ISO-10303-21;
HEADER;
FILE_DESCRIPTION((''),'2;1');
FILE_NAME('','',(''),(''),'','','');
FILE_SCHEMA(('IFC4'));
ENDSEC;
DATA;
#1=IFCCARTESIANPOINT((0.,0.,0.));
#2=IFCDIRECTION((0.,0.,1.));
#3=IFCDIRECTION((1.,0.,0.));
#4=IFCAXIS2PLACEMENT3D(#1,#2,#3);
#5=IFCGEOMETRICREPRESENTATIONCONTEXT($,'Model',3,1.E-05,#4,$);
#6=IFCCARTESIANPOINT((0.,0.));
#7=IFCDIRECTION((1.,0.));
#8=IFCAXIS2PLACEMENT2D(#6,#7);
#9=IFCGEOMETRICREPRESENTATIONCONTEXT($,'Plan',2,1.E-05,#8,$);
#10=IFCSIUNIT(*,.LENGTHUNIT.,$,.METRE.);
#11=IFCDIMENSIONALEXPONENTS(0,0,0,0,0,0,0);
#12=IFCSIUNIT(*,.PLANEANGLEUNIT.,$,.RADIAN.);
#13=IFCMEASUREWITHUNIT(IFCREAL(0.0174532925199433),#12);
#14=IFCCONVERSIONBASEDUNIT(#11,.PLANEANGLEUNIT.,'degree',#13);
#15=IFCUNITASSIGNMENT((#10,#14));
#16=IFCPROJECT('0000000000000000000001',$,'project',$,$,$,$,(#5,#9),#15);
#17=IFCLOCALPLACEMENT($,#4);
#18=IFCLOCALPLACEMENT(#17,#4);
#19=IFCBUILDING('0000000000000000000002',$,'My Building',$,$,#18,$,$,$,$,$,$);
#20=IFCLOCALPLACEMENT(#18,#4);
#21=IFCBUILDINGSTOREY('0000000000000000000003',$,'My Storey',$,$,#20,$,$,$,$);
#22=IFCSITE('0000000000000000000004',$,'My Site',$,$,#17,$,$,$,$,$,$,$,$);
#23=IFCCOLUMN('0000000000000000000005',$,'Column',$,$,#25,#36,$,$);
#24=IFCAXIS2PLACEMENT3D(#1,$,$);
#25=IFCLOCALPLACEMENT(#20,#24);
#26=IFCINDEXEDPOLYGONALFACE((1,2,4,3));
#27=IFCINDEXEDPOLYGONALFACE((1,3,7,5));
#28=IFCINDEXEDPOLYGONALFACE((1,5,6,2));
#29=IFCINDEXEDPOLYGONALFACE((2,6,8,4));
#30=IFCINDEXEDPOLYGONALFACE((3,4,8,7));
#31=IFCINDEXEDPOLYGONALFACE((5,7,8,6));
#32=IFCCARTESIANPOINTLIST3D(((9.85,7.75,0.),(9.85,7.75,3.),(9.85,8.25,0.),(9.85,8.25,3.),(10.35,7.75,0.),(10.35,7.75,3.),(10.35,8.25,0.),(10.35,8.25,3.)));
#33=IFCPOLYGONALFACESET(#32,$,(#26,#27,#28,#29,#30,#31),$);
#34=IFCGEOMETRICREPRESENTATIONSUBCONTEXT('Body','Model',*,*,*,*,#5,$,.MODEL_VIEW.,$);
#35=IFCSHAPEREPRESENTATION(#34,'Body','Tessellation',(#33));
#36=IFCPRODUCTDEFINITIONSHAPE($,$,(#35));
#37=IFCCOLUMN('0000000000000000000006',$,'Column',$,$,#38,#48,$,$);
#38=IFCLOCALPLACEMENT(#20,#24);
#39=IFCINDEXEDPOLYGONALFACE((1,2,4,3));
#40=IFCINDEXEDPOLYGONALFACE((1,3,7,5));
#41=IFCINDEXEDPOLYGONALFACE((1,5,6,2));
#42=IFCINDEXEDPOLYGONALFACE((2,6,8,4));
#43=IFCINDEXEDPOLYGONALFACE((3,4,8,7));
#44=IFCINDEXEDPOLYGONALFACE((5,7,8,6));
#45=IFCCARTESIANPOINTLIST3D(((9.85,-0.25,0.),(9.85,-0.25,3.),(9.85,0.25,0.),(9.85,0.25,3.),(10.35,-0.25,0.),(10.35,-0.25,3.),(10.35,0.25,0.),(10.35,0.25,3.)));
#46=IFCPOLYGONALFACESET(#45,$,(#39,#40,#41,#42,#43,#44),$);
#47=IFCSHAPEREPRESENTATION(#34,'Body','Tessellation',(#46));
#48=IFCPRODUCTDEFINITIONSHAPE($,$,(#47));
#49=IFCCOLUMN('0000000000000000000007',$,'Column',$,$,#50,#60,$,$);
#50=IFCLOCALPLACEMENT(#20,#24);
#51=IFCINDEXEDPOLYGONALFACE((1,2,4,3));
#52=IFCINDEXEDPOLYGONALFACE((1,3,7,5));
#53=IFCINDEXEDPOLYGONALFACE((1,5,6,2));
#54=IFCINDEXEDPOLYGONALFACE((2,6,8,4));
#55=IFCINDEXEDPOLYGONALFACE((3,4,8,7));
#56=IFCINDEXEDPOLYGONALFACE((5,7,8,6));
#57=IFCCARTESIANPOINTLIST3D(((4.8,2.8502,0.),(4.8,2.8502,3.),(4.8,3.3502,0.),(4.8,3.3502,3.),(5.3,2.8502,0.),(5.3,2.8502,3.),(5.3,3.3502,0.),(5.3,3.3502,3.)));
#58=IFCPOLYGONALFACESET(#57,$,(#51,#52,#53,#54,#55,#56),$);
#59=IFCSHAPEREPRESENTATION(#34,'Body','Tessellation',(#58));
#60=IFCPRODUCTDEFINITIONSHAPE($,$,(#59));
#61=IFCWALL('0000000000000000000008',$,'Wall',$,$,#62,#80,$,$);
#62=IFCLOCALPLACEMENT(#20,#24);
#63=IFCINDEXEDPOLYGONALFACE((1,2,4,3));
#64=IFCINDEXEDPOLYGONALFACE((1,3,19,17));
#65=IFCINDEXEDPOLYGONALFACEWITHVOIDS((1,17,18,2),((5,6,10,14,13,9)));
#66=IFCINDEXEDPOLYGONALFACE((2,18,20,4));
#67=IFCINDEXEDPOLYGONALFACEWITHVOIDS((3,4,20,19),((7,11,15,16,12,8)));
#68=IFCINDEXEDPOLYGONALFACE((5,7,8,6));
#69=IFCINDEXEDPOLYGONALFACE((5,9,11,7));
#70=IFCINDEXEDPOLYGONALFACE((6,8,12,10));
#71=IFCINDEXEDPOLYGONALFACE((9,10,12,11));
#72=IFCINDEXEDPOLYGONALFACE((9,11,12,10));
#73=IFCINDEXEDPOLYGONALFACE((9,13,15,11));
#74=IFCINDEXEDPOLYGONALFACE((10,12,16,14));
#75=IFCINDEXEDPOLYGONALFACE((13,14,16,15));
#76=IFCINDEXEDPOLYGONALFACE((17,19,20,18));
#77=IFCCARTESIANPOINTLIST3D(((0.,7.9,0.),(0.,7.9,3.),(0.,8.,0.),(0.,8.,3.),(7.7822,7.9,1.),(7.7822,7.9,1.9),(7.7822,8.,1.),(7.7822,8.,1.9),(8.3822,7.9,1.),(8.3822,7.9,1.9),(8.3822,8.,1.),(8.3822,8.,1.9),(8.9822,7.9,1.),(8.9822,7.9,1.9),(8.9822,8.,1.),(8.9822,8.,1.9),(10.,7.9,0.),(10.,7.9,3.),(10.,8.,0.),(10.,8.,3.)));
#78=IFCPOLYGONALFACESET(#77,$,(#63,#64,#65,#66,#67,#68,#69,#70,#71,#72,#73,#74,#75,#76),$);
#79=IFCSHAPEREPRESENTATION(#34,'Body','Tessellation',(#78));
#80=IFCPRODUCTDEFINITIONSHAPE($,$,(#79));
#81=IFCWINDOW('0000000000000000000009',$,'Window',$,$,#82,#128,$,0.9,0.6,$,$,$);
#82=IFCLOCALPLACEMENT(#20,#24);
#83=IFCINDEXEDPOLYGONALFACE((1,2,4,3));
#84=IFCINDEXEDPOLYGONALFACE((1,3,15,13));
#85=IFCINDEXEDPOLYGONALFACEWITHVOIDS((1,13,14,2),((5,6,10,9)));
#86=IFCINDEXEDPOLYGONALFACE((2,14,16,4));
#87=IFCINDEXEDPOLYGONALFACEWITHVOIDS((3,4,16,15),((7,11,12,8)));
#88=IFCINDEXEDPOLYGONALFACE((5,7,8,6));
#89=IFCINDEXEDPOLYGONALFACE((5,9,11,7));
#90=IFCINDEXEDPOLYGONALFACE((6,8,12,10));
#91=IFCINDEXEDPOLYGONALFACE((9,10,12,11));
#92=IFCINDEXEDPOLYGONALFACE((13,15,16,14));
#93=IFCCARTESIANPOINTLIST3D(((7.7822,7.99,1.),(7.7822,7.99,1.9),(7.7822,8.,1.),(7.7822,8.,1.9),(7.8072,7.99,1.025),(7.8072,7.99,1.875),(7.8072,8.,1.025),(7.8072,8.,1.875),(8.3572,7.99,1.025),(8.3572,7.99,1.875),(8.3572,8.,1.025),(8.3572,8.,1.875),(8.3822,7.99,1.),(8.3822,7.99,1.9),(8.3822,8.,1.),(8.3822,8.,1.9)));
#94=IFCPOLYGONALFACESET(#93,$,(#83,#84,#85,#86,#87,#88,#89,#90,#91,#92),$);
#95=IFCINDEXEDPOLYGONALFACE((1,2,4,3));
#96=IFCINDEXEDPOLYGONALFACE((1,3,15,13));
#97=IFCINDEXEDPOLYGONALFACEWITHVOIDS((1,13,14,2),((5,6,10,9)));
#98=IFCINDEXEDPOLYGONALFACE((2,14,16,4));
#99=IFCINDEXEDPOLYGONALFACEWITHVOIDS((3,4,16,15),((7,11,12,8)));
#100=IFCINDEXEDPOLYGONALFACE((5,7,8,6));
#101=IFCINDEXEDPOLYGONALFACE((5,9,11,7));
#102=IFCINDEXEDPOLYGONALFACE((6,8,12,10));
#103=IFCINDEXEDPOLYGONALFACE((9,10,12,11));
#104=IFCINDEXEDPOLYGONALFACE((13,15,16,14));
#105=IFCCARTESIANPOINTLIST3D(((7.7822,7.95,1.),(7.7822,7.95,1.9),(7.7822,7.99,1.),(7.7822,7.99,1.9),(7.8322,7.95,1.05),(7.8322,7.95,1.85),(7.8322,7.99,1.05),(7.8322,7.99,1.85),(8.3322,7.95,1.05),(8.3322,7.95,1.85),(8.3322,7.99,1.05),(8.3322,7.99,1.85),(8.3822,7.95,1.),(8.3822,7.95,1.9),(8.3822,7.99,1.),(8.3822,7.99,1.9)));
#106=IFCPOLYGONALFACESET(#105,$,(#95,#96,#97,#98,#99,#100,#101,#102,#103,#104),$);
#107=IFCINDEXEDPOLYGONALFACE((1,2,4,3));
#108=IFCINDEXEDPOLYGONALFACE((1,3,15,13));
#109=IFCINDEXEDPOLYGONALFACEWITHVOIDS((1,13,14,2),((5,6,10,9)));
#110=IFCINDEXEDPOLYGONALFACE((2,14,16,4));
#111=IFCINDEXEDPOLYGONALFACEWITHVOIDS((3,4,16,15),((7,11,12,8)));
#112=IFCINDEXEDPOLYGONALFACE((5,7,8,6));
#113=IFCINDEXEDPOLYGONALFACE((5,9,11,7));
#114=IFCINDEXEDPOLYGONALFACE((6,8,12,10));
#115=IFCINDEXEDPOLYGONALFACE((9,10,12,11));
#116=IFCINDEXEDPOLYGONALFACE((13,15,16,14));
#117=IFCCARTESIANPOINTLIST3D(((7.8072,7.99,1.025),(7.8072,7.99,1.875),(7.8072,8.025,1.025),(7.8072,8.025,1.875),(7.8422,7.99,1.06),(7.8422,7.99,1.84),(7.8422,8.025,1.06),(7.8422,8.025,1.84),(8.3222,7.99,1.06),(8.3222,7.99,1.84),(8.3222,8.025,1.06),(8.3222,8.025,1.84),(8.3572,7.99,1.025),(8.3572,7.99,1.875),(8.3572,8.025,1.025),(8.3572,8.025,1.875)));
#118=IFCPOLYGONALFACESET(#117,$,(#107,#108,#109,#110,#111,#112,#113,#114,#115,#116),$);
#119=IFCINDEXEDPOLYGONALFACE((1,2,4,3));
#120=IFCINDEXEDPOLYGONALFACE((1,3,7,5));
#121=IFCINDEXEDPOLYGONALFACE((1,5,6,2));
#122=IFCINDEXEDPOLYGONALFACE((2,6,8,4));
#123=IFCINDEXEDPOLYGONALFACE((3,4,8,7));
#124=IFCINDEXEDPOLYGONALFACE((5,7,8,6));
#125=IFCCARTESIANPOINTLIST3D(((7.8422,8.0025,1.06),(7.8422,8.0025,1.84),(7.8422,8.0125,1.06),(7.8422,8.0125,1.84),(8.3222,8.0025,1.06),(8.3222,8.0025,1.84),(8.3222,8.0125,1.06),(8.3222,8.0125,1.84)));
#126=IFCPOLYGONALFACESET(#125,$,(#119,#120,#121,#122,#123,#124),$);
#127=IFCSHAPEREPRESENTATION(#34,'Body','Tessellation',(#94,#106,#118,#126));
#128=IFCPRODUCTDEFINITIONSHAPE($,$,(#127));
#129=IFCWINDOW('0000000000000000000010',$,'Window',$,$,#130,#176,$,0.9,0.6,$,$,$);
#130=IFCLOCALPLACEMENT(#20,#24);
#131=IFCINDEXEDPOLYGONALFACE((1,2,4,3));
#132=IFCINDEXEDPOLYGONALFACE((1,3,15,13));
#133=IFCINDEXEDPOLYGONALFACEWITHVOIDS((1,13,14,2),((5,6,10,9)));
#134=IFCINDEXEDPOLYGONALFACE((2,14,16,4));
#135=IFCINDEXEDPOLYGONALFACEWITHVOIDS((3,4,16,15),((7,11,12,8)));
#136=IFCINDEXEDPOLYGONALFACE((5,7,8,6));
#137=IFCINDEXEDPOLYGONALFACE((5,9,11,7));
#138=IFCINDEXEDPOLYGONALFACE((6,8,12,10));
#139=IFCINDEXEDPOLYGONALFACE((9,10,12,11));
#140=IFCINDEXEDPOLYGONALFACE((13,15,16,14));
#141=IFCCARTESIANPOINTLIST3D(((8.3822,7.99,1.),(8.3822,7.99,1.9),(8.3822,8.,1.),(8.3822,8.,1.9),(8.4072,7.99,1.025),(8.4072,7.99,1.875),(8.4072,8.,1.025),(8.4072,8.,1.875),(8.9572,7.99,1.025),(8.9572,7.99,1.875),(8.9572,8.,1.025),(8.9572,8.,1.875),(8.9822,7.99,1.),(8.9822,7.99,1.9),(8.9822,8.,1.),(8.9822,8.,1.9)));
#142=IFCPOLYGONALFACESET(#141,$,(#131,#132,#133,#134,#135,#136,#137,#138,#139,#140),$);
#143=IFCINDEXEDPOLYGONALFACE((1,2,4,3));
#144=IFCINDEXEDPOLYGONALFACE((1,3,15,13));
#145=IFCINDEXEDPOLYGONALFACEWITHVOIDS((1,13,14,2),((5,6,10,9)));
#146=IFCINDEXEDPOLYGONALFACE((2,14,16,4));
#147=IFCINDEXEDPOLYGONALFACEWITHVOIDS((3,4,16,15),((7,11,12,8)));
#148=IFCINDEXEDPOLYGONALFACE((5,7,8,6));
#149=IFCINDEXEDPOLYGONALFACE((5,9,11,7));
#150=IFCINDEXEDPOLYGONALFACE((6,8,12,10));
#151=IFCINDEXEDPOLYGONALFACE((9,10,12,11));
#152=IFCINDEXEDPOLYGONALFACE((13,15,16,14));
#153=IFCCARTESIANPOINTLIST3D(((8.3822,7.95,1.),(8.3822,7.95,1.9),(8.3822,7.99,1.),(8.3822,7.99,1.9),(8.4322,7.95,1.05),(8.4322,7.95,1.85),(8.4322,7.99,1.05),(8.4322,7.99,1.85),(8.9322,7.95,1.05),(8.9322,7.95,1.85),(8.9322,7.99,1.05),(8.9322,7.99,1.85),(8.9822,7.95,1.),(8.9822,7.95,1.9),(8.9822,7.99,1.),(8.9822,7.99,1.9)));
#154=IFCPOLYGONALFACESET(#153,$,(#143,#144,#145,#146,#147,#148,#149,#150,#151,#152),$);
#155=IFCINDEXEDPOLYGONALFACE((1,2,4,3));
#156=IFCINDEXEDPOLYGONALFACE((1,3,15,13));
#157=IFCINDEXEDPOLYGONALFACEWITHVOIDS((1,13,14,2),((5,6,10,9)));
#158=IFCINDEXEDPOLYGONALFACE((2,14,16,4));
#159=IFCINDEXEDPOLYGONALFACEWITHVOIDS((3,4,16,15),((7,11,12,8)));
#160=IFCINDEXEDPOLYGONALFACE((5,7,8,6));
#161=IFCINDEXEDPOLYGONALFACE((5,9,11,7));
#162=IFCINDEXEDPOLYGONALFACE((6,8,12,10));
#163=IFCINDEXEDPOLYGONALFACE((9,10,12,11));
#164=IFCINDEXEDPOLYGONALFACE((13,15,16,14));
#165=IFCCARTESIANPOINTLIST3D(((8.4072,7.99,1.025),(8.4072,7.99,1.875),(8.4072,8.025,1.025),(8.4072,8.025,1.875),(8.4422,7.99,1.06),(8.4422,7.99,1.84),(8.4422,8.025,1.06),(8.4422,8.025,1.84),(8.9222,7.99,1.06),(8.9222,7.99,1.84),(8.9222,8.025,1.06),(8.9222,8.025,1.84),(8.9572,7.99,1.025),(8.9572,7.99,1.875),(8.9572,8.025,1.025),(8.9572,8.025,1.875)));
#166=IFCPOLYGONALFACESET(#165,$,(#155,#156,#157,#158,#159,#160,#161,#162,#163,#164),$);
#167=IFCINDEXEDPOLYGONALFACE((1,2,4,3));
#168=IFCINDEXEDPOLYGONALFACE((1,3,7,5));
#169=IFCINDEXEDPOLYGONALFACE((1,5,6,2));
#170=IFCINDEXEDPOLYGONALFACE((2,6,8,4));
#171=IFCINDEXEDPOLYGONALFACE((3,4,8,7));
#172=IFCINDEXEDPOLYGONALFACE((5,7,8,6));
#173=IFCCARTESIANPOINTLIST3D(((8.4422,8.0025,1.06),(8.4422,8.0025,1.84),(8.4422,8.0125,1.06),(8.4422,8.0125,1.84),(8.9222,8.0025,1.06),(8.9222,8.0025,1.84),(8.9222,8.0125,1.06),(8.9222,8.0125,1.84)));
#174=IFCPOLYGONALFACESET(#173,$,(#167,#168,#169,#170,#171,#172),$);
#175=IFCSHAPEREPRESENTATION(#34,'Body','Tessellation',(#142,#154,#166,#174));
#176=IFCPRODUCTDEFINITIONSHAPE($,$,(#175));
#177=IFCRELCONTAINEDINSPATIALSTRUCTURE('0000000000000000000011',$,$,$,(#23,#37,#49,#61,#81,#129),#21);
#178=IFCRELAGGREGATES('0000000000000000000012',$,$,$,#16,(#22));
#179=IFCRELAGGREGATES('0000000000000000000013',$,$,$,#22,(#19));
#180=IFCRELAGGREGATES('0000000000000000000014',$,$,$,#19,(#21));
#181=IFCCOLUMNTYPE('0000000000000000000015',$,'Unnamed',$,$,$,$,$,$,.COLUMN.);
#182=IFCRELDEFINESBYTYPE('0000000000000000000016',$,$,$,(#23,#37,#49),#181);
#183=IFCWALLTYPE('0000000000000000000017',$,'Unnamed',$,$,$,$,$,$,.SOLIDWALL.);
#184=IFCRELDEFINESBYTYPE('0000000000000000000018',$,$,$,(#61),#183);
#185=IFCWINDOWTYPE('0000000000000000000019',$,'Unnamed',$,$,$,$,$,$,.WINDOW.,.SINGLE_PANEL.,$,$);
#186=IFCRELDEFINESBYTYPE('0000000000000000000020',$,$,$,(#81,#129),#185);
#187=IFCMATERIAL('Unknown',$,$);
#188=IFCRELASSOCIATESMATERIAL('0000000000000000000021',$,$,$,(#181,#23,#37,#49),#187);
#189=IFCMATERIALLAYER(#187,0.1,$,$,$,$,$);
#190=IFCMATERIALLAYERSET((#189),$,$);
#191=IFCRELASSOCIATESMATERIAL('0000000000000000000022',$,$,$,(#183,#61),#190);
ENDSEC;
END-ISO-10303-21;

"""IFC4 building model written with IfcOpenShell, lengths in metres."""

from ifc_helpers import new_model, entity, si_unit, converted_unit, frame, origin_with_axes, origin_2d_with_axis, place, context, subcontext, project, spatial, line, indexed_curve, rectangle, outline, extrude, shape, source, transform, mapped, material, layer, layer_set, layer_usage, material_profile, profile_set, profile_usage, type_object, type_shapes, element, fill, save


model = new_model("IFC4")

# Units and contexts
model_context = context("Model", 3, precision=1e-05, world=origin_with_axes())
plan_context = context("Plan", 2, precision=1e-05, world=origin_2d_with_axis())
body_context_1 = subcontext(model_context, "Body", "Model", "MODEL_VIEW")
body_context_2 = subcontext(plan_context, "Body", "Plan", "PLAN_VIEW")
ifc_project = project(units=[si_unit("LENGTHUNIT", "METRE"), converted_unit("PLANEANGLEUNIT", "degree", entity("IfcReal", 0.0174532925199433), si_unit("PLANEANGLEUNIT", "RADIAN"), dimensions=[0, 0, 0, 0, 0, 0, 0])], contexts=[model_context, plan_context])

# Site, building, storey
site_placement = place(None, origin_with_axes())
site = spatial("IfcSite", under=ifc_project, at=site_placement, Name="My Site")
building_placement = place(site_placement, origin_with_axes())
building = spatial("IfcBuilding", under=site, at=building_placement, Name="My Building")
storey_placement = place(building_placement, origin_with_axes())
storey = spatial("IfcBuildingStorey", under=building, at=storey_placement, Name="My Storey")

# Columns
ifc_material = material(Name="Unknown")
ifc_material_profile = material_profile(ifc_material, rectangle(XDim=0.5, YDim=0.5))
ifc_profile_set = profile_set([ifc_material_profile])
ifc_profile_usage_1 = profile_usage(ifc_profile_set, cardinal=5)
column_type = type_object("IfcColumnType", Name="Unnamed", PredefinedType="COLUMN", material=ifc_profile_set)
column_1_placement = place(storey_placement, frame((10.1, 8.0, 0.0), z_axis=(0.0, 0.0, 1.0), x_axis=(1.0, 0.0, 0.0)))
element("IfcColumn", 1, at=column_1_placement, inside=storey, type_object=column_type, material=ifc_profile_usage_1, Name="Column", context=body_context_1, shape_type="SweptSolid", body=[
    extrude(rectangle(XDim=0.5, YDim=0.5), origin_with_axes(), (0.0, 0.0, 1.0), 3.0),
])
ifc_profile_usage_2 = profile_usage(ifc_profile_set, cardinal=5)
column_2_placement = place(storey_placement, frame((10.1, 0.0, 0.0), z_axis=(0.0, 0.0, 1.0), x_axis=(1.0, 0.0, 0.0)))
element("IfcColumn", 2, at=column_2_placement, inside=storey, type_object=column_type, material=ifc_profile_usage_2, Name="Column", context=body_context_1, shape_type="SweptSolid", body=[
    extrude(rectangle(XDim=0.5, YDim=0.5), origin_with_axes(), (0.0, 0.0, 1.0), 3.0),
])
ifc_profile_usage_3 = profile_usage(ifc_profile_set, cardinal=5)
column_3_placement = place(storey_placement, frame((5.05, 3.1002, 0.0), z_axis=(0.0, 0.0, 1.0), x_axis=(1.0, 0.0, 0.0)))
element("IfcColumn", 3, at=column_3_placement, inside=storey, type_object=column_type, material=ifc_profile_usage_3, Name="Column", context=body_context_1, shape_type="SweptSolid", body=[
    extrude(rectangle(XDim=0.5, YDim=0.5), origin_with_axes(), (0.0, 0.0, 1.0), 3.0),
])

# Shared definitions
ifc_layer = layer(ifc_material, 0.1)
ifc_layer_set = layer_set([ifc_layer])
wall_type = type_object("IfcWallType", Name="Unnamed", PredefinedType="SOLIDWALL", material=ifc_layer_set)
shared_shape_1 = source(origin_with_axes(), body_context_1, "Body", "SweptSolid", [
    extrude(outline(indexed_curve([(0.0, 0.0), (0.6, 0.0), (0.6, 0.9), (0.0, 0.9)], segments=[line(1, 2, 3, 4, 1)])), frame((0.0, -0.6, 0.0), z_axis=(0.0, -1.0, 0.0), x_axis=(1.0, 0.0, 0.0)), (0.0, 0.0, -1.0), 1.2),
])
window_type = type_object("IfcWindowType", Name="Unnamed", PartitioningType="SINGLE_PANEL", PredefinedType="WINDOW")
shared_shape_2 = source(origin_with_axes(), body_context_1, "Body", "SweptSolid", [
    extrude(outline(indexed_curve([(0.0, 0.0), (0.6, 0.0), (0.6, 0.9), (0.0, 0.9)], segments=[line(1, 2, 3, 4, 1)]), holes=[indexed_curve([(0.025, 0.025), (0.575, 0.025), (0.575, 0.875), (0.025, 0.875)], segments=[line(1, 2, 3, 4, 1)])]), frame((0.0, 0.09, 0.0), z_axis=(0.0, -1.0, 0.0), x_axis=(1.0, 0.0, 0.0)), (0.0, 0.0, -1.0), 0.01),
    extrude(outline(indexed_curve([(0.0, 0.0), (0.6, 0.0), (0.6, 0.9), (0.0, 0.9)], segments=[line(1, 2, 3, 4, 1)]), holes=[indexed_curve([(0.05, 0.05), (0.55, 0.05), (0.55, 0.85), (0.05, 0.85)], segments=[line(1, 2, 3, 4, 1)])]), frame((0.0, 0.05, 0.0), z_axis=(0.0, -1.0, 0.0), x_axis=(1.0, 0.0, 0.0)), (0.0, 0.0, -1.0), 0.04),
    extrude(outline(indexed_curve([(0.0, 0.0), (0.55, 0.0), (0.55, 0.85), (0.0, 0.85)], segments=[line(1, 2, 3, 4, 1)]), holes=[indexed_curve([(0.035, 0.035), (0.515, 0.035), (0.515, 0.815), (0.035, 0.815)], segments=[line(1, 2, 3, 4, 1)])]), frame((0.025, 0.09, 0.025), z_axis=(0.0, -1.0, 0.0), x_axis=(1.0, 0.0, 0.0)), (0.0, 0.0, -1.0), 0.035),
    extrude(outline(indexed_curve([(0.035, 0.035), (0.515, 0.035), (0.515, 0.815), (0.035, 0.815)], segments=[line(1, 2, 3, 4, 1)])), frame((0.025, 0.1025, 0.025), z_axis=(0.0, -1.0, 0.0), x_axis=(1.0, 0.0, 0.0)), (0.0, 0.0, -1.0), 0.01),
])
shared_shape_3 = source(origin_with_axes(), body_context_2, "Body", "Curve2D", [
    entity("IfcIndexedPolyCurve", entity("IfcCartesianPointList2D", [[0.05, 0.05], [0.55, 0.05]])),
    entity("IfcIndexedPolyCurve", entity("IfcCartesianPointList2D", [[0.0, 0.1], [0.025, 0.1], [0.025, 0.09], [0.05, 0.09], [0.05, 0.05], [0.0, 0.05]]), [entity("IfcLineIndex", [1, 2, 3, 4, 5, 6, 1])]),
    entity("IfcIndexedPolyCurve", entity("IfcCartesianPointList2D", [[0.6, 0.1], [0.575, 0.1], [0.575, 0.09], [0.55, 0.09], [0.55, 0.05], [0.6, 0.05]]), [entity("IfcLineIndex", [1, 2, 3, 4, 5, 6, 1])]),
    entity("IfcIndexedPolyCurve", entity("IfcCartesianPointList2D", [[0.025, 0.09], [0.06, 0.09], [0.06, 0.125], [0.025, 0.125]]), [entity("IfcLineIndex", [1, 2, 3, 4, 1])]),
    entity("IfcIndexedPolyCurve", entity("IfcCartesianPointList2D", [[0.575, 0.09], [0.54, 0.09], [0.54, 0.125], [0.575, 0.125]]), [entity("IfcLineIndex", [1, 2, 3, 4, 1])]),
    entity("IfcIndexedPolyCurve", entity("IfcCartesianPointList2D", [[0.06, 0.09], [0.54, 0.09]])),
    entity("IfcIndexedPolyCurve", entity("IfcCartesianPointList2D", [[0.06, 0.125], [0.54, 0.125]])),
    entity("IfcIndexedPolyCurve", entity("IfcCartesianPointList2D", [[0.06, 0.1075], [0.54, 0.1075]])),
])
type_shapes(window_type, [shared_shape_2, shared_shape_3])

# Wall, openings, windows
ifc_layer_usage_1 = layer_usage(ifc_layer_set, "AXIS2", "POSITIVE", 0.0)
wall_1_placement = place(storey_placement, frame((0.0, 7.9, 0.0), z_axis=(0.0, 0.0, 1.0), x_axis=(1.0, 0.0, 0.0)))
wall_1 = element("IfcWall", 4, at=wall_1_placement, inside=storey, type_object=wall_type, material=ifc_layer_usage_1, Name="Wall", context=body_context_1, shape_type="SweptSolid", body=[
    extrude(outline(indexed_curve([(0.0, 0.0), (0.0, 0.1), (10.0, 0.1), (10.0, 0.0)], segments=[line(1, 2, 3, 4, 1)])), origin_with_axes(), (0.0, 0.0, 1.0), 3.0),
])
opening_1_placement = place(wall_1_placement, frame((7.7822, 0.0, 1.0), z_axis=(0.0, 0.0, 1.0), x_axis=(1.0, 0.0, 0.0)))
opening_1 = element("IfcOpeningElement", 5, at=opening_1_placement, cuts=wall_1, PredefinedType="OPENING", context=body_context_1, shape_type="MappedRepresentation", body=[
    mapped(shared_shape_1, transform((0.0, 0.0, 0.0), x_axis=(1.0, 0.0, 0.0), y_axis=(0.0, 1.0, 0.0), z_axis=(0.0, 0.0, 1.0), scale=1.0)),
])
opening_2_placement = place(wall_1_placement, frame((8.3822, 0.0, 1.0), z_axis=(0.0, 0.0, 1.0), x_axis=(1.0, 0.0, 0.0)))
opening_2 = element("IfcOpeningElement", 6, at=opening_2_placement, cuts=wall_1, PredefinedType="OPENING", context=body_context_1, shape_type="MappedRepresentation", body=[
    mapped(shared_shape_1, transform((0.0, 0.0, 0.0), x_axis=(1.0, 0.0, 0.0), y_axis=(0.0, 1.0, 0.0), z_axis=(0.0, 0.0, 1.0), scale=1.0)),
])
window_1_placement = place(opening_1_placement, origin_with_axes())
window_1 = element("IfcWindow", 7, at=window_1_placement, inside=storey, type_object=window_type, Name="Window", OverallHeight=0.9, OverallWidth=0.6, shapes=[
    shape(body_context_1, "Body", "MappedRepresentation", [mapped(shared_shape_2, transform((0.0, 0.0, 0.0), x_axis=(1.0, 0.0, 0.0), y_axis=(0.0, 1.0, 0.0), z_axis=(0.0, 0.0, 1.0), scale=1.0))]),
    shape(body_context_2, "Body", "MappedRepresentation", [mapped(shared_shape_3, transform((0.0, 0.0, 0.0), x_axis=(1.0, 0.0, 0.0), y_axis=(0.0, 1.0, 0.0), z_axis=(0.0, 0.0, 1.0), scale=1.0))]),
])
fill(opening_1, window_1)
window_2_placement = place(opening_2_placement, origin_with_axes())
window_2 = element("IfcWindow", 8, at=window_2_placement, inside=storey, type_object=window_type, Name="Window", OverallHeight=0.9, OverallWidth=0.6, shapes=[
    shape(body_context_1, "Body", "MappedRepresentation", [mapped(shared_shape_2, transform((0.0, 0.0, 0.0), x_axis=(1.0, 0.0, 0.0), y_axis=(0.0, 1.0, 0.0), z_axis=(0.0, 0.0, 1.0), scale=1.0))]),
    shape(body_context_2, "Body", "MappedRepresentation", [mapped(shared_shape_3, transform((0.0, 0.0, 0.0), x_axis=(1.0, 0.0, 0.0), y_axis=(0.0, 1.0, 0.0), z_axis=(0.0, 0.0, 1.0), scale=1.0))]),
])
fill(opening_2, window_2)

save(model, "model.ifc")
